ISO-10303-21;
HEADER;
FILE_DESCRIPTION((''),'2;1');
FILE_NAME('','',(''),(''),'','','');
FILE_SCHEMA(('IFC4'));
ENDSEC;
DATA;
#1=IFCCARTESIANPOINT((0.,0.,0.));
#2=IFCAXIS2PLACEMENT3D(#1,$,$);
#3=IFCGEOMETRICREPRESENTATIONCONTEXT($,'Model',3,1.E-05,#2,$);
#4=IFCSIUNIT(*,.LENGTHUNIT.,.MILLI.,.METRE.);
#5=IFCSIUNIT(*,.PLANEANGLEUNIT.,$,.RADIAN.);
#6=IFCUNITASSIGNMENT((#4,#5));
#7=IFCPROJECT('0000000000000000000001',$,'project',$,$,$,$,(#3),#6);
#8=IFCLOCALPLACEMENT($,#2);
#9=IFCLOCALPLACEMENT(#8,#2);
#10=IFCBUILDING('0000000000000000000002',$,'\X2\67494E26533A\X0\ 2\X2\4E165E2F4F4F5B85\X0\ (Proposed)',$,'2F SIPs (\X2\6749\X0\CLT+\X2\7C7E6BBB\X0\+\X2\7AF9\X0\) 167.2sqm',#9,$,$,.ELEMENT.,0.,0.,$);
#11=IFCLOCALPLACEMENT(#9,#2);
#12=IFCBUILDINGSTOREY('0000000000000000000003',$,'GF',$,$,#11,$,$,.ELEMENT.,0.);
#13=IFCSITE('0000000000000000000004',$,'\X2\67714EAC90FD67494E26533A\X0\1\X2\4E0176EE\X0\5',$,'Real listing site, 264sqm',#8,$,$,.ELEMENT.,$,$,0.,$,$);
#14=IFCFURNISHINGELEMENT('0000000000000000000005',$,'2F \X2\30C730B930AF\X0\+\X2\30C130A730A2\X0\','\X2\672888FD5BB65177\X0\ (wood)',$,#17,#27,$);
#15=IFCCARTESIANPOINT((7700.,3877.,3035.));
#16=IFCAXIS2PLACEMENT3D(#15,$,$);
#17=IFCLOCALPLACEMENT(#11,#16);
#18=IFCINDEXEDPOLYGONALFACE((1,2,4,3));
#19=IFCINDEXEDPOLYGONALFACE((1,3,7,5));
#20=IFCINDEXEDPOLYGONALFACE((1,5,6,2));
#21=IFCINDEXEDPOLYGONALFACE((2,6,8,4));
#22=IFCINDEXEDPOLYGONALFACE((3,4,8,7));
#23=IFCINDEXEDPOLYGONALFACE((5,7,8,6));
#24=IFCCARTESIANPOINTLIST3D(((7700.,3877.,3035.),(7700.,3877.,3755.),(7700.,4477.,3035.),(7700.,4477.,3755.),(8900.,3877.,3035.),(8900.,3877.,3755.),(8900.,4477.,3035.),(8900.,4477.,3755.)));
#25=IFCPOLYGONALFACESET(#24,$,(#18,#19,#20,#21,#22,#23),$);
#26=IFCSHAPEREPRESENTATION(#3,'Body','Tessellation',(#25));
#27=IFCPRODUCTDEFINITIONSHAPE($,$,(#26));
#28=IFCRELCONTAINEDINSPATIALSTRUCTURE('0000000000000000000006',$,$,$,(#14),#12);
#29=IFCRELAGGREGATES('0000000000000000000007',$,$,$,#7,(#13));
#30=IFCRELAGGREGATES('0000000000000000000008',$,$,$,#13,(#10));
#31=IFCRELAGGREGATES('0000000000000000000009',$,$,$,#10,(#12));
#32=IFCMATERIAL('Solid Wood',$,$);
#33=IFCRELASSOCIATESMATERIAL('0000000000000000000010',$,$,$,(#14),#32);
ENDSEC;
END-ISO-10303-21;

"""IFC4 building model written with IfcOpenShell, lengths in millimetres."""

from ifc_helpers import new_model, si_unit, frame, frame_2d, origin, place, context, project, spatial, rectangle, extrude, material, element, save


model = new_model("IFC4")

# Units and contexts
model_context = context("Model", 3, precision=1e-05, world=origin())
ifc_project = project(units=[si_unit("LENGTHUNIT", "METRE", prefix="MILLI"), si_unit("PLANEANGLEUNIT", "RADIAN")], contexts=[model_context])

# Site, building, storey
site_placement = place(None, origin())
site = spatial("IfcSite", under=ifc_project, at=site_placement, Name="東京都杉並区1丁目5", ObjectType="Real listing site, 264sqm", CompositionType="ELEMENT", RefElevation=0.0)
building_placement = place(site_placement, origin())
building = spatial("IfcBuilding", under=site, at=building_placement, Name="杉並区 2世帯住宅 (Proposed)", ObjectType="2F SIPs (杉CLT+籾殻+竹) 167.2sqm", CompositionType="ELEMENT", ElevationOfRefHeight=0.0, ElevationOfTerrain=0.0)
storey_placement = place(building_placement, origin())
storey = spatial("IfcBuildingStorey", under=building, at=storey_placement, Name="GF", CompositionType="ELEMENT", Elevation=0.0)

# Shared definitions
ifc_material_1 = material(Name="Solid Wood")

# Furnishing element
furnishing_1_placement = place(storey_placement, frame((7700.0, 3877.0, 3035.0)))
element("IfcFurnishingElement", 1, at=furnishing_1_placement, inside=storey, material=ifc_material_1, Name="2F デスク+チェア", Description="木製家具 (wood)", context=model_context, shape_type="SweptSolid", body=[
    extrude(rectangle(XDim=1200.0, YDim=600.0, at=frame_2d((600.0, 300.0))), frame((7700.0, 3877.0, 3035.0)), (0.0, 0.0, 1.0), 720.0),
])

save(model, "model.ifc")
